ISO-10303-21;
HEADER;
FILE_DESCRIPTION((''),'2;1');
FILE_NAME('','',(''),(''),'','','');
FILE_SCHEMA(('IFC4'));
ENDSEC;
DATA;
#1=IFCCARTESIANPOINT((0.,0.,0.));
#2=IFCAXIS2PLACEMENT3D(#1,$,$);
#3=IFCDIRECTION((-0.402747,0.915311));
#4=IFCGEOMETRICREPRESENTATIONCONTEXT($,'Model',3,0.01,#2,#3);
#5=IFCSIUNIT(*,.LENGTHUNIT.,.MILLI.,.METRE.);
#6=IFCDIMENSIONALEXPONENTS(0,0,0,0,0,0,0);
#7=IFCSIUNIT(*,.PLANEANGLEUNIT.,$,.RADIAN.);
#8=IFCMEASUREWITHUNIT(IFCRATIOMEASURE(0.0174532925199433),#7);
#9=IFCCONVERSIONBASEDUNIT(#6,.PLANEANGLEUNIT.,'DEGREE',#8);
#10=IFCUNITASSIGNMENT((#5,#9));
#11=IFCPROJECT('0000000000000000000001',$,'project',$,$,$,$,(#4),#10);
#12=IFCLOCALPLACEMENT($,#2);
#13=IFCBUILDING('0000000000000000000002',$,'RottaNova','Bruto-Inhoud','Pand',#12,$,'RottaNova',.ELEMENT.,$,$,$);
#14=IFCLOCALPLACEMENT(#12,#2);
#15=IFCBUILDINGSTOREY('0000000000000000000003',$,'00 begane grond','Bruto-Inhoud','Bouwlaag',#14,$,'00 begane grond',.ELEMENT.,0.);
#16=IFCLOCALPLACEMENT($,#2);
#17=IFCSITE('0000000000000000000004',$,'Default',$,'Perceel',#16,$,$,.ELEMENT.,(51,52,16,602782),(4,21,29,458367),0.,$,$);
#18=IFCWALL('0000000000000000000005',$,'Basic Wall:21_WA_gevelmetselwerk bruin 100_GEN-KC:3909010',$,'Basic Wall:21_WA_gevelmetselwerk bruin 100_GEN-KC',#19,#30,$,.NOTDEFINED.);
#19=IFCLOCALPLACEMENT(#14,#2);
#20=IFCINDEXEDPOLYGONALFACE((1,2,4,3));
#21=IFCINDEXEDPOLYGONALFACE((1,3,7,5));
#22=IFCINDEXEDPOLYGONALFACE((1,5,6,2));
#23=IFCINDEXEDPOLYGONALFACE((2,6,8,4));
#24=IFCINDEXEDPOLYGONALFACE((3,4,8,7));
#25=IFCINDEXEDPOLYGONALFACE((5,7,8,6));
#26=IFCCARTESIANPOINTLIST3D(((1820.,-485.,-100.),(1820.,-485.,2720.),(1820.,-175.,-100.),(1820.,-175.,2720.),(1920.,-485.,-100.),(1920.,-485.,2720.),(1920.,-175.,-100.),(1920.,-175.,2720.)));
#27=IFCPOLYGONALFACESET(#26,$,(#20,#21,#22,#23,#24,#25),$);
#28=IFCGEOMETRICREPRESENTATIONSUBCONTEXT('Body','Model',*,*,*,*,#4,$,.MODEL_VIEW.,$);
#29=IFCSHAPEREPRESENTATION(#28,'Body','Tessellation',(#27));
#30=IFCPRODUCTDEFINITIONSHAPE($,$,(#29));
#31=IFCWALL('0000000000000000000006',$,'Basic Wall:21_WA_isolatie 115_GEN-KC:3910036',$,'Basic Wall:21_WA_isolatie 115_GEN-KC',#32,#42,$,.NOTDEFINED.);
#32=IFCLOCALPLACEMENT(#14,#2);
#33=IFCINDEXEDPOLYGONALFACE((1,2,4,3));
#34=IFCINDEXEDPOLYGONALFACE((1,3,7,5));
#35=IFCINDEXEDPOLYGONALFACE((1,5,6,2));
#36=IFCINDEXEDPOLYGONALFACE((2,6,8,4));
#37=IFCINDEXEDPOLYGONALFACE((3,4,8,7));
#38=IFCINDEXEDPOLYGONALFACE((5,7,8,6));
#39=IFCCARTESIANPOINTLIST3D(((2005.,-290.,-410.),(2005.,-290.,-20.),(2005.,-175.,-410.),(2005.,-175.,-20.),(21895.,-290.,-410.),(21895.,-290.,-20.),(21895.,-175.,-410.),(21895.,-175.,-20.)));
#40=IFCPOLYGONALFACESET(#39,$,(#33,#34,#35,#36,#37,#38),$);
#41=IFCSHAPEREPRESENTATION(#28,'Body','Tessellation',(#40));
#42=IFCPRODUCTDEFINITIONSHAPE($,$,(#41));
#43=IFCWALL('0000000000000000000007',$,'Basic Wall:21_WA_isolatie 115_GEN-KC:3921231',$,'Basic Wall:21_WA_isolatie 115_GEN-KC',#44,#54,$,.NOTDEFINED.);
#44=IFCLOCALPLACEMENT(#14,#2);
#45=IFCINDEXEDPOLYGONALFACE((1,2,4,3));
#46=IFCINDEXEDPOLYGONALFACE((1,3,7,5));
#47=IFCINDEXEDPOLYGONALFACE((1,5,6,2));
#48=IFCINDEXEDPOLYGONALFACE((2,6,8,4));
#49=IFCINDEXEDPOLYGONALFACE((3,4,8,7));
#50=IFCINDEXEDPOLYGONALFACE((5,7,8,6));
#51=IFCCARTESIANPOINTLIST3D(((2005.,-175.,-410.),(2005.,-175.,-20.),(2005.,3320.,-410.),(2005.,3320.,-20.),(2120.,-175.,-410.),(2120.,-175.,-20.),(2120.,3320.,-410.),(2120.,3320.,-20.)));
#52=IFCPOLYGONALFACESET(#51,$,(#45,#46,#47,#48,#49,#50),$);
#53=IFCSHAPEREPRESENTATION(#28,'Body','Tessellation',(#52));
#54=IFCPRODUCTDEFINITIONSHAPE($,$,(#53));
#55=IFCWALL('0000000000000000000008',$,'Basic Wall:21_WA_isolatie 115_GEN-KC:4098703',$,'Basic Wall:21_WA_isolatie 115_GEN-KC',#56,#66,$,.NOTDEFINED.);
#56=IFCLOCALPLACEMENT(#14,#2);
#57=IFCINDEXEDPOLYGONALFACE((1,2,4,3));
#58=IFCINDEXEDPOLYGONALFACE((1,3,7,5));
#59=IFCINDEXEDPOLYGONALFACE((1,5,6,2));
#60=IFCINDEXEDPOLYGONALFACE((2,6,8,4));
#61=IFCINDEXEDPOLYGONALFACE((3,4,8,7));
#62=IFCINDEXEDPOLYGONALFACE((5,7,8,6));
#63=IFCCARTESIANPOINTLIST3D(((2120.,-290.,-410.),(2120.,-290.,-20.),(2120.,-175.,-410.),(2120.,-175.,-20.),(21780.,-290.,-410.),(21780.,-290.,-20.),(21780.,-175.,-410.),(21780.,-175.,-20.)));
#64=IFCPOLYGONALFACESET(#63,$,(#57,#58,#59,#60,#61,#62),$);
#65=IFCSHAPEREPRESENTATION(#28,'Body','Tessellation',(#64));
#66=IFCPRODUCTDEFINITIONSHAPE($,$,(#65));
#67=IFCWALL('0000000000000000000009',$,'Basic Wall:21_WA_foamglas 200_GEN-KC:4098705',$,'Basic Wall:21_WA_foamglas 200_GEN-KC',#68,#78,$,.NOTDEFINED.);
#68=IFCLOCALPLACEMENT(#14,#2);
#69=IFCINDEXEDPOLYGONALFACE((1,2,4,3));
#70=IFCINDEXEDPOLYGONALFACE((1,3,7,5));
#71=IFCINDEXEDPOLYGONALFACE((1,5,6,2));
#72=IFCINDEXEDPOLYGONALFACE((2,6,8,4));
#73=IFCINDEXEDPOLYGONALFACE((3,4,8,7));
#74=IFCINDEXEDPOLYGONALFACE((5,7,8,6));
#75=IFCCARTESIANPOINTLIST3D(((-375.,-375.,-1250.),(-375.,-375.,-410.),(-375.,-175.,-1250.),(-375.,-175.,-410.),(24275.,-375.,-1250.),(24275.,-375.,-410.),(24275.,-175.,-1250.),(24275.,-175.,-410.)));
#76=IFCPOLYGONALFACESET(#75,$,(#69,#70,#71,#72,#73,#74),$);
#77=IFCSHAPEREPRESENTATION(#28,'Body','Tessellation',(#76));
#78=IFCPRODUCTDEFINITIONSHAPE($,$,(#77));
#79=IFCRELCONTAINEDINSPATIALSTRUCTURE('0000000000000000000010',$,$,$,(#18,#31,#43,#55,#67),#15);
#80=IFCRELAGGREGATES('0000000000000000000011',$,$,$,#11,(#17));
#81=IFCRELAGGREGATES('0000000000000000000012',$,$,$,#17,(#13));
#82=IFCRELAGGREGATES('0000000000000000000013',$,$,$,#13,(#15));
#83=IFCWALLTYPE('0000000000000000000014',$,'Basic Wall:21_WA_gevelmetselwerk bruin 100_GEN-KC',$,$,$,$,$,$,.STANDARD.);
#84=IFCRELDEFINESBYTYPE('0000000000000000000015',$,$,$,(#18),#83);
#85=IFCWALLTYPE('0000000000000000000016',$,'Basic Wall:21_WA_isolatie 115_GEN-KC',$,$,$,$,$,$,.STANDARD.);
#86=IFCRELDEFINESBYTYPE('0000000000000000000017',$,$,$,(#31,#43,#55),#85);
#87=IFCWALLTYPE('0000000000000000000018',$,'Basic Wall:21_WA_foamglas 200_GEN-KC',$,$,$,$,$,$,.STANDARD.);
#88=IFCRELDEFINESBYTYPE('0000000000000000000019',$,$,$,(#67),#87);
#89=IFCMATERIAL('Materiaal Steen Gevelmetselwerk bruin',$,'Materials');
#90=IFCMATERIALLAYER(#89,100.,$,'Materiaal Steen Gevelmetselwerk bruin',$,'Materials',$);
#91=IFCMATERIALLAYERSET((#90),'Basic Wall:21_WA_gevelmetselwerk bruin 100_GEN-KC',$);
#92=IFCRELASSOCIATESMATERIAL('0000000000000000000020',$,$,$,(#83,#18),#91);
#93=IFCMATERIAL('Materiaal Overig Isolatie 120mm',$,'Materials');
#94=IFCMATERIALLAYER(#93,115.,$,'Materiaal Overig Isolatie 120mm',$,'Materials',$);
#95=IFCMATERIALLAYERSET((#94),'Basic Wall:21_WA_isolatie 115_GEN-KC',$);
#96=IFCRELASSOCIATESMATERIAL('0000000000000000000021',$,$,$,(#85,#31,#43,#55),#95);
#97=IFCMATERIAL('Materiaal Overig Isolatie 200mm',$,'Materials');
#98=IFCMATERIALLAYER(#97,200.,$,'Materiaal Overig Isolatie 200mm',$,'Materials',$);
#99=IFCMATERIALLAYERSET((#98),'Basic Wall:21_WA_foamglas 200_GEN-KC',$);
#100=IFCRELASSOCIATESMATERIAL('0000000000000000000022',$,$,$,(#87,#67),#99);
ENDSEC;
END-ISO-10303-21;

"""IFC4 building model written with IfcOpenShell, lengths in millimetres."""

from ifc_helpers import new_model, entity, si_unit, converted_unit, direction, frame, frame_2d, origin, place, context, subcontext, project, spatial, rectangle, extrude, material, layer, layer_set, type_object, element, save


model = new_model("IFC4")

# Units and contexts
model_context = context("Model", 3, precision=0.01, world=origin(), true_north=direction((-0.402747, 0.915311)))
body_context = subcontext(model_context, "Body", "Model", "MODEL_VIEW")
ifc_project = project(units=[si_unit("LENGTHUNIT", "METRE", prefix="MILLI"), converted_unit("PLANEANGLEUNIT", "DEGREE", entity("IfcRatioMeasure", 0.0174532925199433), si_unit("PLANEANGLEUNIT", "RADIAN"), dimensions=[0, 0, 0, 0, 0, 0, 0])], contexts=[model_context])

# Site, building, storey
site_placement = place(None, origin())
site = spatial("IfcSite", under=ifc_project, at=site_placement, Name="Default", ObjectType="Perceel", CompositionType="ELEMENT", RefLatitude=(51, 52, 16, 602782), RefLongitude=(4, 21, 29, 458367), RefElevation=0.0)
building_placement = place(None, origin())
building = spatial("IfcBuilding", under=site, at=building_placement, Name="RottaNova", Description="Bruto-Inhoud", ObjectType="Pand", LongName="RottaNova", CompositionType="ELEMENT")
storey_placement = place(building_placement, origin())
storey = spatial("IfcBuildingStorey", under=building, at=storey_placement, Name="00 begane grond", Description="Bruto-Inhoud", ObjectType="Bouwlaag", LongName="00 begane grond", CompositionType="ELEMENT", Elevation=0.0)

# Walls
ifc_material_1 = material(Name="Materiaal Steen Gevelmetselwerk bruin", Category="Materials")
ifc_layer_1 = layer(ifc_material_1, 100.0, Name="Materiaal Steen Gevelmetselwerk bruin", Category="Materials")
ifc_layer_set_1 = layer_set([ifc_layer_1], Name="Basic Wall:21_WA_gevelmetselwerk bruin 100_GEN-KC")
wall_type_1 = type_object("IfcWallType", Name="Basic Wall:21_WA_gevelmetselwerk bruin 100_GEN-KC", PredefinedType="STANDARD", material=ifc_layer_set_1)
wall_1_placement = place(storey_placement, frame((1870.0, -175.0, -100.0), z_axis=(0.0, 0.0, 1.0), x_axis=(0.0, -1.0, 0.0)))
element("IfcWall", 1, at=wall_1_placement, inside=storey, type_object=wall_type_1, material=ifc_layer_set_1, Name="Basic Wall:21_WA_gevelmetselwerk bruin 100_GEN-KC:3909010", ObjectType="Basic Wall:21_WA_gevelmetselwerk bruin 100_GEN-KC", PredefinedType="NOTDEFINED", context=body_context, shape_type="SweptSolid", body=[
    extrude(rectangle(XDim=310.0, YDim=100.0, at=frame_2d((155.0, 0.0), x_axis=(-1.0, 0.0))), origin(), (0.0, 0.0, 1.0), 2820.0),
])
ifc_material_2 = material(Name="Materiaal Overig Isolatie 120mm", Category="Materials")
ifc_layer_2 = layer(ifc_material_2, 115.0, Name="Materiaal Overig Isolatie 120mm", Category="Materials")
ifc_layer_set_2 = layer_set([ifc_layer_2], Name="Basic Wall:21_WA_isolatie 115_GEN-KC")
wall_type_2 = type_object("IfcWallType", Name="Basic Wall:21_WA_isolatie 115_GEN-KC", PredefinedType="STANDARD", material=ifc_layer_set_2)
wall_2_placement = place(storey_placement, frame((2005.0, -232.5, -410.0)))
element("IfcWall", 2, at=wall_2_placement, inside=storey, type_object=wall_type_2, material=ifc_layer_set_2, Name="Basic Wall:21_WA_isolatie 115_GEN-KC:3910036", ObjectType="Basic Wall:21_WA_isolatie 115_GEN-KC", PredefinedType="NOTDEFINED", context=body_context, shape_type="SweptSolid", body=[
    extrude(rectangle(XDim=19890.0, YDim=115.0, at=frame_2d((9945.0, 0.0), x_axis=(-1.0, 0.0))), origin(), (0.0, 0.0, 1.0), 390.0),
])
wall_3_placement = place(storey_placement, frame((2062.5, -175.0, -410.0), z_axis=(0.0, 0.0, 1.0), x_axis=(0.0, 1.0, 0.0)))
element("IfcWall", 3, at=wall_3_placement, inside=storey, type_object=wall_type_2, material=ifc_layer_set_2, Name="Basic Wall:21_WA_isolatie 115_GEN-KC:3921231", ObjectType="Basic Wall:21_WA_isolatie 115_GEN-KC", PredefinedType="NOTDEFINED", context=body_context, shape_type="SweptSolid", body=[
    extrude(rectangle(XDim=3495.0, YDim=115.0, at=frame_2d((1747.5, 0.0), x_axis=(-1.0, 0.0))), origin(), (0.0, 0.0, 1.0), 390.0),
])
wall_4_placement = place(storey_placement, frame((2120.0, -232.5, -410.0)))
element("IfcWall", 4, at=wall_4_placement, inside=storey, type_object=wall_type_2, material=ifc_layer_set_2, Name="Basic Wall:21_WA_isolatie 115_GEN-KC:4098703", ObjectType="Basic Wall:21_WA_isolatie 115_GEN-KC", PredefinedType="NOTDEFINED", context=body_context, shape_type="SweptSolid", body=[
    extrude(rectangle(XDim=19660.0, YDim=115.0, at=frame_2d((9830.0, 0.0), x_axis=(-1.0, 0.0))), origin(), (0.0, 0.0, 1.0), 390.0),
])
ifc_material_3 = material(Name="Materiaal Overig Isolatie 200mm", Category="Materials")
ifc_layer_3 = layer(ifc_material_3, 200.0, Name="Materiaal Overig Isolatie 200mm", Category="Materials")
ifc_layer_set_3 = layer_set([ifc_layer_3], Name="Basic Wall:21_WA_foamglas 200_GEN-KC")
wall_type_3 = type_object("IfcWallType", Name="Basic Wall:21_WA_foamglas 200_GEN-KC", PredefinedType="STANDARD", material=ifc_layer_set_3)
wall_5_placement = place(storey_placement, frame((-375.0, -275.0, -1250.0)))
element("IfcWall", 5, at=wall_5_placement, inside=storey, type_object=wall_type_3, material=ifc_layer_set_3, Name="Basic Wall:21_WA_foamglas 200_GEN-KC:4098705", ObjectType="Basic Wall:21_WA_foamglas 200_GEN-KC", PredefinedType="NOTDEFINED", context=body_context, shape_type="SweptSolid", body=[
    extrude(rectangle(XDim=24650.0, YDim=200.0, at=frame_2d((12325.0, 0.0), x_axis=(-1.0, 0.0))), origin(), (0.0, 0.0, 1.0), 840.0),
])

save(model, "model.ifc")
